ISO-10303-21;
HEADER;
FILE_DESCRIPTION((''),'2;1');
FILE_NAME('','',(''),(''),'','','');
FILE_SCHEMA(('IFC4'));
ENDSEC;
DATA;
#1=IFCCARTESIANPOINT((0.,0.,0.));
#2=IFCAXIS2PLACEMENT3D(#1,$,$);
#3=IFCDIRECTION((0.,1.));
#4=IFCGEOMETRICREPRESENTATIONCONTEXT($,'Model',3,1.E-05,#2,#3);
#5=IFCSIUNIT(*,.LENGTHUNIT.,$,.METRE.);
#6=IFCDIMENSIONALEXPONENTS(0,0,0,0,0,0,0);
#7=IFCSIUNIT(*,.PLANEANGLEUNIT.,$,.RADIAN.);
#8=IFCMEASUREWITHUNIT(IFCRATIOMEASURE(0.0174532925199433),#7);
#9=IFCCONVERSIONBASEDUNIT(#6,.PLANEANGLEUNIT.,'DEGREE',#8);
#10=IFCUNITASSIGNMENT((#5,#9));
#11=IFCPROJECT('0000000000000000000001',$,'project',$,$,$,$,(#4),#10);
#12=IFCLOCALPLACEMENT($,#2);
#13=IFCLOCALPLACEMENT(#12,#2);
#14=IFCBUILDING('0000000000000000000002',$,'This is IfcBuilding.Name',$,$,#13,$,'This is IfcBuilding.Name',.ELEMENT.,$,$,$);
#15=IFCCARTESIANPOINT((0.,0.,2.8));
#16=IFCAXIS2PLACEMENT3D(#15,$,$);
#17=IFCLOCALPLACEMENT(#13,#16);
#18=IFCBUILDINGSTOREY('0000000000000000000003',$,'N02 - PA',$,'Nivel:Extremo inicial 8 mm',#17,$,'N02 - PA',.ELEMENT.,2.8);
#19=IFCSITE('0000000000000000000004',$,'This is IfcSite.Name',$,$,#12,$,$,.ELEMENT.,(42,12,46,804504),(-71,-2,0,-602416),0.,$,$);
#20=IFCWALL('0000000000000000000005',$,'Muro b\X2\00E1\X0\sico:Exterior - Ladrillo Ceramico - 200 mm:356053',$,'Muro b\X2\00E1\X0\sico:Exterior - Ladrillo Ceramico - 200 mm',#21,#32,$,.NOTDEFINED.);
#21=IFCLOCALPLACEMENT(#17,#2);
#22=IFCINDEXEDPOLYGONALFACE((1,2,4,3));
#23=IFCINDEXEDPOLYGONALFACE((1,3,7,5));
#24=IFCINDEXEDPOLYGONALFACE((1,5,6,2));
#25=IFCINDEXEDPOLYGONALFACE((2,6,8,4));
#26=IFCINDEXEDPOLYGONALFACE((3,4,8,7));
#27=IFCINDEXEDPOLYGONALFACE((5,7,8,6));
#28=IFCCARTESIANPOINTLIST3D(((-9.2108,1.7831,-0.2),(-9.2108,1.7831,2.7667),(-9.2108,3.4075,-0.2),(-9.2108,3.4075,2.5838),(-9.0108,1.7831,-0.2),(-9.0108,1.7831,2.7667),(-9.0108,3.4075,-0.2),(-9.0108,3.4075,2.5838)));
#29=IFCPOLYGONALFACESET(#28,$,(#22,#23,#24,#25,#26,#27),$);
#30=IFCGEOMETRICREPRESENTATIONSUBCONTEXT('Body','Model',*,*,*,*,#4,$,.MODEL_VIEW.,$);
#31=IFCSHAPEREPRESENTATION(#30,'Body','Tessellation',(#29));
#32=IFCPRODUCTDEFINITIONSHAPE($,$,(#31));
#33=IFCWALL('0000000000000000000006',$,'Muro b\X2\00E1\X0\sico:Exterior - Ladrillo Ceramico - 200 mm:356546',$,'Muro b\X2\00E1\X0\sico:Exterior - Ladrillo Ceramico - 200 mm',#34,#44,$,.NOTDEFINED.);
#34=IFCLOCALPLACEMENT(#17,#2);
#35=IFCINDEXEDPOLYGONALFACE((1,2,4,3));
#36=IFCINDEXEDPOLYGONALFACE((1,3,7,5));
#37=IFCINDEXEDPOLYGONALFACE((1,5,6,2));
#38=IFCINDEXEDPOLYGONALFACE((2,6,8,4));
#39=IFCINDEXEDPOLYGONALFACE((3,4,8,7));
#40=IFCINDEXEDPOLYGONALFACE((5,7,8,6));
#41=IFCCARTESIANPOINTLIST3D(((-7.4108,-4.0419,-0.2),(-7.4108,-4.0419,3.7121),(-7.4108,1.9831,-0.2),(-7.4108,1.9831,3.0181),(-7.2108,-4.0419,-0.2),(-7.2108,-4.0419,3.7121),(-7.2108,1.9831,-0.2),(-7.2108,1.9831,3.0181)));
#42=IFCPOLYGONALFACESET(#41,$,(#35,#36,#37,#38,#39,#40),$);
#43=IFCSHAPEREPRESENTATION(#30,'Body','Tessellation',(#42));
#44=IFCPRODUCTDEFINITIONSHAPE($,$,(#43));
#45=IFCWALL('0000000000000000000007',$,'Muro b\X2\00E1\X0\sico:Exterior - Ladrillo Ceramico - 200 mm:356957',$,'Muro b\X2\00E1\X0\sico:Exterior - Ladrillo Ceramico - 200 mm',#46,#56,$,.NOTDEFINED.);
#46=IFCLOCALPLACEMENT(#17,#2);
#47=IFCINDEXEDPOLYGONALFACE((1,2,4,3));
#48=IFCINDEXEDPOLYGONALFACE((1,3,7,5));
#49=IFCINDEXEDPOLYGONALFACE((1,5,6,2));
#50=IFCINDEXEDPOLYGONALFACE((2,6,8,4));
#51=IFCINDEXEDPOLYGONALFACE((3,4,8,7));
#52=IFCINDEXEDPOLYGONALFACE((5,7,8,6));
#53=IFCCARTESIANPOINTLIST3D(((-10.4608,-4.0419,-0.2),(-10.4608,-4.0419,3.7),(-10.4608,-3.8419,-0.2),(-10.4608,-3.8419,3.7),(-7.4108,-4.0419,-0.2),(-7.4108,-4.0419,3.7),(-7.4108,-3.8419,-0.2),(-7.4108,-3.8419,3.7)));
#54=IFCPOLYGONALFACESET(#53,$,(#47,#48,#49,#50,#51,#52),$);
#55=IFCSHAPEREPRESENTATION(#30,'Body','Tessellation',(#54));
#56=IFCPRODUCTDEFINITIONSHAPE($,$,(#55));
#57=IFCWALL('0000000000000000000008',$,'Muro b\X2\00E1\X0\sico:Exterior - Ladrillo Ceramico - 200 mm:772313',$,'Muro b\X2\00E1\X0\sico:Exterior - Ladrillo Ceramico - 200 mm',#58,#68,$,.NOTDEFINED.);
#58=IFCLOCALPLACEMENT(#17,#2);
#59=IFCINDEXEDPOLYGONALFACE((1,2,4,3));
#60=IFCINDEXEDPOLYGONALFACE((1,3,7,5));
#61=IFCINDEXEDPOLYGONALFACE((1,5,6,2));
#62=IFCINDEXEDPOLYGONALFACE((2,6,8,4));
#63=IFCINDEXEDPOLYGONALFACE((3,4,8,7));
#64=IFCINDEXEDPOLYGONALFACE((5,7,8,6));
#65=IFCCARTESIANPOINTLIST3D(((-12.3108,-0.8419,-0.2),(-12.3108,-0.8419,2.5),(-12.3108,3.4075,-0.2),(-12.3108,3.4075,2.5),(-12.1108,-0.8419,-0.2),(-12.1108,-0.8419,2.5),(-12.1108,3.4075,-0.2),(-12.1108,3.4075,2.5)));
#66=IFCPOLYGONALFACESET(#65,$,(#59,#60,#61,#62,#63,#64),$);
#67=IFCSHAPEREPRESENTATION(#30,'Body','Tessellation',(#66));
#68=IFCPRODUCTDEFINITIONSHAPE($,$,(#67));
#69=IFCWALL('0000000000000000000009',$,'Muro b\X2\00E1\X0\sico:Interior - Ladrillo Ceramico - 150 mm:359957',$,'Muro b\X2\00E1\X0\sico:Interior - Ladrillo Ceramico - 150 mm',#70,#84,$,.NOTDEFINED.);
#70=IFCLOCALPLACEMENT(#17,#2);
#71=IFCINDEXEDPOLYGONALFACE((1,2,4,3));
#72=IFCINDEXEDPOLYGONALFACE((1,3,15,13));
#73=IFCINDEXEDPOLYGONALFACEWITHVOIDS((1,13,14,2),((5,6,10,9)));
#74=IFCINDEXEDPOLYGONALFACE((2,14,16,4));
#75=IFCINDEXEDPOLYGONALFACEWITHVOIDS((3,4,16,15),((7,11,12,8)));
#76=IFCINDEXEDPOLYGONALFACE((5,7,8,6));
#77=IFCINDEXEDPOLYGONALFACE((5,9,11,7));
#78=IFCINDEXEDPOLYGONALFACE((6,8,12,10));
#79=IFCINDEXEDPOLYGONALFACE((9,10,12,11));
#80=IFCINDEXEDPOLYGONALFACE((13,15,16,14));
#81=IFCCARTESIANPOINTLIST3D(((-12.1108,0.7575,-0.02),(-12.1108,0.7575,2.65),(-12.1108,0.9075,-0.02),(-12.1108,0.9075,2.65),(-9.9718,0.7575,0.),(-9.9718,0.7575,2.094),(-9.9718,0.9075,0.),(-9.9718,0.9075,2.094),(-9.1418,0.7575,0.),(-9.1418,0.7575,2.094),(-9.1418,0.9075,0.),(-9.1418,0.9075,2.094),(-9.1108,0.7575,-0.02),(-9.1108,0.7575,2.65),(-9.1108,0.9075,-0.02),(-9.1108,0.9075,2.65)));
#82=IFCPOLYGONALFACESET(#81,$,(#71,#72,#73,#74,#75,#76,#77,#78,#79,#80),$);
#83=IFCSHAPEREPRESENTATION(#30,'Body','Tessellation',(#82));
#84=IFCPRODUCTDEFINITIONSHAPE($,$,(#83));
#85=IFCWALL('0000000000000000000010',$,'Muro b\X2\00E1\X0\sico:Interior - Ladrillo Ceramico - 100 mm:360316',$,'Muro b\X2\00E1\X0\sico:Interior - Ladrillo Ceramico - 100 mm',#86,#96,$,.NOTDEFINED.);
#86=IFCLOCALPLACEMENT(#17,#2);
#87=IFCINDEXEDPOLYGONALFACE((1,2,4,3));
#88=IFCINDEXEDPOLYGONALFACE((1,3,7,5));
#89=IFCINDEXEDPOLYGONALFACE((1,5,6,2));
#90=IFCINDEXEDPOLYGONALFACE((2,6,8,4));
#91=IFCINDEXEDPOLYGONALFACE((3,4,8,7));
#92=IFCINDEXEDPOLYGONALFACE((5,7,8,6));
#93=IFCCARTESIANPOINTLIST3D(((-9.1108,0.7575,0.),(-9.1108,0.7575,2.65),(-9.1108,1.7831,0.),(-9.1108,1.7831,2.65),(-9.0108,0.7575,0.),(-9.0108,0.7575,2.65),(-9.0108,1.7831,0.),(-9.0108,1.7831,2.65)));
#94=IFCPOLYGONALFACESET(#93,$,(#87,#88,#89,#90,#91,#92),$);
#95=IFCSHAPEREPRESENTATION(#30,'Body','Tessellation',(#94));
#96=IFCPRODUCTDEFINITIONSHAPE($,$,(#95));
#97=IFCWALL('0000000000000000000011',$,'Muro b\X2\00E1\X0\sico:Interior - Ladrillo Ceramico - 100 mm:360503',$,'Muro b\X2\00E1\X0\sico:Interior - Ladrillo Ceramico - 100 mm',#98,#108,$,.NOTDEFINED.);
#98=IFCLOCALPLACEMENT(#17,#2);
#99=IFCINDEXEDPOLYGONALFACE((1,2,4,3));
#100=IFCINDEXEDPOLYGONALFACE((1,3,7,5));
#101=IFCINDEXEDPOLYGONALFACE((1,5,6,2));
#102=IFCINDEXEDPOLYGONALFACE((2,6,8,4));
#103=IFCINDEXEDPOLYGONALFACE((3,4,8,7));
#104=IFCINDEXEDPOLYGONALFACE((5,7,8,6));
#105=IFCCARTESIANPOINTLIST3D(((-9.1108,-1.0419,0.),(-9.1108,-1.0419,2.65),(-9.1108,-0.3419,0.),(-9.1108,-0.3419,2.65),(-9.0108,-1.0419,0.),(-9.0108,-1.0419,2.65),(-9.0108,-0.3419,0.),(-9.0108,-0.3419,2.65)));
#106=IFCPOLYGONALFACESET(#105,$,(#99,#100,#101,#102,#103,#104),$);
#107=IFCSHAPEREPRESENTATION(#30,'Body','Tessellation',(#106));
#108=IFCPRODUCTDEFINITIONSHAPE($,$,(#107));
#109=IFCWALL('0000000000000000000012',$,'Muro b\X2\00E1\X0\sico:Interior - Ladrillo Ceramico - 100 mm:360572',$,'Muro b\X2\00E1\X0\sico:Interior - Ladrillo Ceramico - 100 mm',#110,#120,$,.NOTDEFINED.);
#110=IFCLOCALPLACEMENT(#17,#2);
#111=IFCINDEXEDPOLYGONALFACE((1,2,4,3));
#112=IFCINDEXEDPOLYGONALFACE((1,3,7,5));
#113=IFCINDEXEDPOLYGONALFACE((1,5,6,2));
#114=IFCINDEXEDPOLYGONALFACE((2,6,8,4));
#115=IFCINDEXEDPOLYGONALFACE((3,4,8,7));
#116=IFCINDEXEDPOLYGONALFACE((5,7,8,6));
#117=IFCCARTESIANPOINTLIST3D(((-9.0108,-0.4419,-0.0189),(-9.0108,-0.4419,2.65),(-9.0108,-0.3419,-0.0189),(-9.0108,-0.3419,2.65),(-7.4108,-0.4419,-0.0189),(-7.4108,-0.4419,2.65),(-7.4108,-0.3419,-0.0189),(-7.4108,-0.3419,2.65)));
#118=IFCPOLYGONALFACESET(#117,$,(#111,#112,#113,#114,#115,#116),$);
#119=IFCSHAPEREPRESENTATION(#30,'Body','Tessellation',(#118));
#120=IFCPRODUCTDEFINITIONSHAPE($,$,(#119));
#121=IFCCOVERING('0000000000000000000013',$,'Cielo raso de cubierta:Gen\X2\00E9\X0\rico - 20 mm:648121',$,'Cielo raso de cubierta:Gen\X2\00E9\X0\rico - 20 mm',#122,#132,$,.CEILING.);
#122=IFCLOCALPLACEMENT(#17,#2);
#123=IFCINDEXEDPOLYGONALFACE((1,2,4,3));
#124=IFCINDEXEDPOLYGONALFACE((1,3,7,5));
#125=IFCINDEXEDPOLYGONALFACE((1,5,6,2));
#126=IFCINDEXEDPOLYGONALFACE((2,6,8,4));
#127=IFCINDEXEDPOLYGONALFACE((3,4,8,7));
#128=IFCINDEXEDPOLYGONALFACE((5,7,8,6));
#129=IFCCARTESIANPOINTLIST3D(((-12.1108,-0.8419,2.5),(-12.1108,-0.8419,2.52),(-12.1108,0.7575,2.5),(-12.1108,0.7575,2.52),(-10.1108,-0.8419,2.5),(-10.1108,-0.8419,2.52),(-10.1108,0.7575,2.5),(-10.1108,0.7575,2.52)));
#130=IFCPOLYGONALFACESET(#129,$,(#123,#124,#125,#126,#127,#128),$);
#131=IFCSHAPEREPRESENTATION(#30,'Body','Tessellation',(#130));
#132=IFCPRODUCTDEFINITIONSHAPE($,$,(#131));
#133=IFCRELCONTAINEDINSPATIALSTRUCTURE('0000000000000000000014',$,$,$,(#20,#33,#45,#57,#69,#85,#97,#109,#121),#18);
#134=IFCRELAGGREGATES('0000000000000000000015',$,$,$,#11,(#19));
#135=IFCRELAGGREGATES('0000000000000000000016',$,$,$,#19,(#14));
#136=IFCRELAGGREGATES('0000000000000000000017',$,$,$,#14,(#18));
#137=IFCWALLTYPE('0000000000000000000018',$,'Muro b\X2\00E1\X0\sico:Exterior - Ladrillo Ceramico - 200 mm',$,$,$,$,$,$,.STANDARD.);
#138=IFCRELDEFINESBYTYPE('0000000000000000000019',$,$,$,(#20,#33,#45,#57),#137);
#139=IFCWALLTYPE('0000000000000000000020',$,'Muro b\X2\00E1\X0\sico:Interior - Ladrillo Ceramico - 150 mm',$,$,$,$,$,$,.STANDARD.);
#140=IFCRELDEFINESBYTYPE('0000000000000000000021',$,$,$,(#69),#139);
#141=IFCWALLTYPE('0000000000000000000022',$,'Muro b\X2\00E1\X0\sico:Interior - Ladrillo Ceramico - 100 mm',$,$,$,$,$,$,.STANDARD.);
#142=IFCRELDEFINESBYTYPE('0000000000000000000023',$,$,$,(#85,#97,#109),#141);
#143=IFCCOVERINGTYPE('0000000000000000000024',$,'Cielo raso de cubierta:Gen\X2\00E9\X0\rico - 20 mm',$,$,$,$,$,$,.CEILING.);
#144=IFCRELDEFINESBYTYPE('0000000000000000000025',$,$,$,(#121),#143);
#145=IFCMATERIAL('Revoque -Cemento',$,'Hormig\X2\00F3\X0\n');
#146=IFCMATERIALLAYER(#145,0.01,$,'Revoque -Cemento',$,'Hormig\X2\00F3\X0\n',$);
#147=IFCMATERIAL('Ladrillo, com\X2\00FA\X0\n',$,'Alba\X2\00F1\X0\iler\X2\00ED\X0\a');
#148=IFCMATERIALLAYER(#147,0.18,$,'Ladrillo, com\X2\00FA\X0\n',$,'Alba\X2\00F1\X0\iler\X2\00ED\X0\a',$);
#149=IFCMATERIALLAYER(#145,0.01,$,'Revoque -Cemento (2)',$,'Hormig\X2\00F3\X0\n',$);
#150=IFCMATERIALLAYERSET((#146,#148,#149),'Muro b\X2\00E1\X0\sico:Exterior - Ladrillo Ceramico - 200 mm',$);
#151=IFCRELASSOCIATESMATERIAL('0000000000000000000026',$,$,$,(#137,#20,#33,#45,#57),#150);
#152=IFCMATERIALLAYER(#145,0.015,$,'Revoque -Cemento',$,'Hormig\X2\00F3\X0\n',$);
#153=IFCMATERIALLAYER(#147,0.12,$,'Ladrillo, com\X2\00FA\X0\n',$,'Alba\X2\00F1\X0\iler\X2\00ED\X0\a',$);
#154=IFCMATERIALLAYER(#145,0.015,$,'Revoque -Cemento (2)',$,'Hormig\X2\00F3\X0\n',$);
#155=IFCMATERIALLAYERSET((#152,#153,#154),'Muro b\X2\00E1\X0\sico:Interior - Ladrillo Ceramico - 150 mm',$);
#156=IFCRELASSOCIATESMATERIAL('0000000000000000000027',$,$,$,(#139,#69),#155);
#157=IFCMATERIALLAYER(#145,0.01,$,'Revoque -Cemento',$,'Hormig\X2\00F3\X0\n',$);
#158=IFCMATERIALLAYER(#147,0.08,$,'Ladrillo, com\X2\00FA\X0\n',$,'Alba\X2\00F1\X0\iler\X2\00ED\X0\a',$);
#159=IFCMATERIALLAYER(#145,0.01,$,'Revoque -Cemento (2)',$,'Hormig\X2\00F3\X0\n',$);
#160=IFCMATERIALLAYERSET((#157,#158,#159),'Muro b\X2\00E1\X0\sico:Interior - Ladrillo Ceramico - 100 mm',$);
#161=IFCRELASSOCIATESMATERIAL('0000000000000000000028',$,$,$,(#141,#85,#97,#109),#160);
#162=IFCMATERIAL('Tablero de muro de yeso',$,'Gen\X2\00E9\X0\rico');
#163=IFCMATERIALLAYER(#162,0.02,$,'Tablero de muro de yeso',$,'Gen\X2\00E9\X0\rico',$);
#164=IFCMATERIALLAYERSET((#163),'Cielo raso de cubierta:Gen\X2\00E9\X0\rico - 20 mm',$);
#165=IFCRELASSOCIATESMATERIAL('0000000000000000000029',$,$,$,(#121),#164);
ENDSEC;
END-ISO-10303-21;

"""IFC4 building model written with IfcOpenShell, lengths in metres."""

from ifc_helpers import new_model, entity, si_unit, converted_unit, direction, frame, frame_2d, origin, place, context, subcontext, project, spatial, polyline, rectangle, extrude, clip, halfspace, bounded_halfspace, material, layer, layer_set, layer_usage, type_object, element, save


model = new_model("IFC4")

# Units and contexts
model_context = context("Model", 3, precision=1e-05, world=origin(), true_north=direction((0.0, 1.0)))
body_context = subcontext(model_context, "Body", "Model", "MODEL_VIEW")
ifc_project = project(units=[si_unit("LENGTHUNIT", "METRE"), converted_unit("PLANEANGLEUNIT", "DEGREE", entity("IfcRatioMeasure", 0.0174532925199433), si_unit("PLANEANGLEUNIT", "RADIAN"), dimensions=[0, 0, 0, 0, 0, 0, 0])], contexts=[model_context])

# Site, building, storey
site_placement = place(None, origin())
site = spatial("IfcSite", under=ifc_project, at=site_placement, Name="This is IfcSite.Name", CompositionType="ELEMENT", RefLatitude=(42, 12, 46, 804504), RefLongitude=(-71, -2, 0, -602416), RefElevation=0.0)
building_placement = place(site_placement, origin())
building = spatial("IfcBuilding", under=site, at=building_placement, Name="This is IfcBuilding.Name", LongName="This is IfcBuilding.Name", CompositionType="ELEMENT")
storey_placement = place(building_placement, frame((0.0, 0.0, 2.8)))
storey = spatial("IfcBuildingStorey", under=building, at=storey_placement, Name="N02 - PA", ObjectType="Nivel:Extremo inicial 8 mm", LongName="N02 - PA", CompositionType="ELEMENT", Elevation=2.8)

# Shared definitions
ifc_material_1 = material(Name="Revoque -Cemento", Category="Hormigón")

# Walls
ifc_layer_1 = layer(ifc_material_1, 0.01, Name="Revoque -Cemento", Category="Hormigón")
ifc_material_2 = material(Name="Ladrillo, común", Category="Albañilería")
ifc_layer_2 = layer(ifc_material_2, 0.18, Name="Ladrillo, común", Category="Albañilería")
ifc_layer_3 = layer(ifc_material_1, 0.01, Name="Revoque -Cemento (2)", Category="Hormigón")
ifc_layer_set_1 = layer_set([ifc_layer_1, ifc_layer_2, ifc_layer_3], Name="Muro básico:Exterior - Ladrillo Ceramico - 200 mm")
ifc_layer_usage_1 = layer_usage(ifc_layer_set_1, "AXIS2", "NEGATIVE", 0.1)
wall_type_1 = type_object("IfcWallType", Name="Muro básico:Exterior - Ladrillo Ceramico - 200 mm", PredefinedType="STANDARD", material=ifc_layer_set_1)
wall_1_placement = place(storey_placement, frame((-9.1108, 3.4075, -0.2), z_axis=(0.0, 0.0, 1.0), x_axis=(0.0, -1.0, 0.0)))
element("IfcWall", 1, at=wall_1_placement, inside=storey, type_object=wall_type_1, material=ifc_layer_usage_1, Name="Muro básico:Exterior - Ladrillo Ceramico - 200 mm:356053", ObjectType="Muro básico:Exterior - Ladrillo Ceramico - 200 mm", PredefinedType="NOTDEFINED", context=body_context, shape_type="Clipping", body=[
    clip(extrude(rectangle(XDim=1.6244, YDim=0.2, at=frame_2d((0.8122, 0.0), x_axis=(-1.0, 0.0))), origin(), (0.0, 0.0, 1.0), 2.9667), bounded_halfspace(frame((0.0, -0.1, 2.7838), z_axis=(-0.111886, 0.0, 0.993721), x_axis=(0.0, -1.0, 0.0)), False, frame((0.0, -0.1, 2.7838)), polyline([(0.0, 0.0), (1.6244, 0.0), (1.6244, 0.2), (1.4244, 0.2), (1.3244, 0.2), (0.0, 0.2), (0.0, 0.0)]))),
])
ifc_layer_usage_2 = layer_usage(ifc_layer_set_1, "AXIS2", "NEGATIVE", 0.1)
wall_2_placement = place(storey_placement, frame((-7.3108, 1.9831, -0.2), z_axis=(0.0, 0.0, 1.0), x_axis=(0.0, -1.0, 0.0)))
element("IfcWall", 2, at=wall_2_placement, inside=storey, type_object=wall_type_1, material=ifc_layer_usage_2, Name="Muro básico:Exterior - Ladrillo Ceramico - 200 mm:356546", ObjectType="Muro básico:Exterior - Ladrillo Ceramico - 200 mm", PredefinedType="NOTDEFINED", context=body_context, shape_type="Clipping", body=[
    clip(extrude(rectangle(XDim=6.025, YDim=0.2, at=frame_2d((3.0125, 0.0), x_axis=(-1.0, 0.0))), origin(), (0.0, 0.0, 1.0), 3.9121), halfspace(frame((0.0, -0.1, 3.2181), z_axis=(-0.114424, 0.0, 0.993432), x_axis=(0.0, 1.0, 0.0)), False)),
])
ifc_layer_usage_3 = layer_usage(ifc_layer_set_1, "AXIS2", "NEGATIVE", 0.1)
wall_3_placement = place(storey_placement, frame((-7.4108, -3.9419, -0.2), z_axis=(0.0, 0.0, 1.0), x_axis=(-1.0, 0.0, 0.0)))
element("IfcWall", 3, at=wall_3_placement, inside=storey, type_object=wall_type_1, material=ifc_layer_usage_3, Name="Muro básico:Exterior - Ladrillo Ceramico - 200 mm:356957", ObjectType="Muro básico:Exterior - Ladrillo Ceramico - 200 mm", PredefinedType="NOTDEFINED", context=body_context, shape_type="SweptSolid", body=[
    extrude(rectangle(XDim=3.05, YDim=0.2, at=frame_2d((1.525, 0.0), x_axis=(-1.0, 0.0))), origin(), (0.0, 0.0, 1.0), 3.9),
])
ifc_layer_usage_4 = layer_usage(ifc_layer_set_1, "AXIS2", "POSITIVE", -0.1)
wall_4_placement = place(storey_placement, frame((-12.2108, 3.4075, -0.2), z_axis=(0.0, 0.0, 1.0), x_axis=(0.0, -1.0, 0.0)))
element("IfcWall", 4, at=wall_4_placement, inside=storey, type_object=wall_type_1, material=ifc_layer_usage_4, Name="Muro básico:Exterior - Ladrillo Ceramico - 200 mm:772313", ObjectType="Muro básico:Exterior - Ladrillo Ceramico - 200 mm", PredefinedType="NOTDEFINED", context=body_context, shape_type="SweptSolid", body=[
    extrude(rectangle(XDim=4.2494, YDim=0.2, at=frame_2d((2.1247, 0.0), x_axis=(-1.0, 0.0))), origin(), (0.0, 0.0, 1.0), 2.7),
])

# Wall, opening
ifc_layer_4 = layer(ifc_material_1, 0.015, Name="Revoque -Cemento", Category="Hormigón")
ifc_layer_5 = layer(ifc_material_2, 0.12, Name="Ladrillo, común", Category="Albañilería")
ifc_layer_6 = layer(ifc_material_1, 0.015, Name="Revoque -Cemento (2)", Category="Hormigón")
ifc_layer_set_2 = layer_set([ifc_layer_4, ifc_layer_5, ifc_layer_6], Name="Muro básico:Interior - Ladrillo Ceramico - 150 mm")
ifc_layer_usage_5 = layer_usage(ifc_layer_set_2, "AXIS2", "NEGATIVE", 0.075)
wall_type_2 = type_object("IfcWallType", Name="Muro básico:Interior - Ladrillo Ceramico - 150 mm", PredefinedType="STANDARD", material=ifc_layer_set_2)
wall_5_placement = place(storey_placement, frame((-9.1108, 0.8325, -0.02), z_axis=(0.0, 0.0, 1.0), x_axis=(-1.0, 0.0, 0.0)))
wall_5 = element("IfcWall", 5, at=wall_5_placement, inside=storey, type_object=wall_type_2, material=ifc_layer_usage_5, Name="Muro básico:Interior - Ladrillo Ceramico - 150 mm:359957", ObjectType="Muro básico:Interior - Ladrillo Ceramico - 150 mm", PredefinedType="NOTDEFINED", context=body_context, shape_type="SweptSolid", body=[
    extrude(rectangle(XDim=3.0, YDim=0.15, at=frame_2d((1.5, 0.0), x_axis=(-1.0, 0.0))), origin(), (0.0, 0.0, 1.0), 2.67),
])
opening_1_placement = place(wall_5_placement, frame((0.861, 0.075, 0.02)))
element("IfcOpeningElement", 6, at=opening_1_placement, cuts=wall_5, PredefinedType="OPENING", context=body_context, shape_type="SweptSolid", body=[
    extrude(rectangle(XDim=2.094, YDim=0.83, at=frame_2d((1.047, 0.415), x_axis=(-1.0, 0.0))), frame((0.0, 0.0, 0.0), z_axis=(0.0, -1.0, 0.0), x_axis=(0.0, 0.0, 1.0)), (0.0, 0.0, 1.0), 0.15),
])

# Walls
ifc_layer_7 = layer(ifc_material_1, 0.01, Name="Revoque -Cemento", Category="Hormigón")
ifc_layer_8 = layer(ifc_material_2, 0.08, Name="Ladrillo, común", Category="Albañilería")
ifc_layer_9 = layer(ifc_material_1, 0.01, Name="Revoque -Cemento (2)", Category="Hormigón")
ifc_layer_set_3 = layer_set([ifc_layer_7, ifc_layer_8, ifc_layer_9], Name="Muro básico:Interior - Ladrillo Ceramico - 100 mm")
ifc_layer_usage_6 = layer_usage(ifc_layer_set_3, "AXIS2", "NEGATIVE", 0.05)
wall_type_3 = type_object("IfcWallType", Name="Muro básico:Interior - Ladrillo Ceramico - 100 mm", PredefinedType="STANDARD", material=ifc_layer_set_3)
wall_6_placement = place(storey_placement, frame((-9.0608, 1.7831, 0.0), z_axis=(0.0, 0.0, 1.0), x_axis=(0.0, -1.0, 0.0)))
element("IfcWall", 7, at=wall_6_placement, inside=storey, type_object=wall_type_3, material=ifc_layer_usage_6, Name="Muro básico:Interior - Ladrillo Ceramico - 100 mm:360316", ObjectType="Muro básico:Interior - Ladrillo Ceramico - 100 mm", PredefinedType="NOTDEFINED", context=body_context, shape_type="SweptSolid", body=[
    extrude(rectangle(XDim=1.0256, YDim=0.1, at=frame_2d((0.5128, 0.0), x_axis=(-1.0, 0.0))), origin(), (0.0, 0.0, 1.0), 2.65),
])
ifc_layer_usage_7 = layer_usage(ifc_layer_set_3, "AXIS2", "POSITIVE", -0.05)
wall_7_placement = place(storey_placement, frame((-9.0608, -1.0419, 0.0), z_axis=(0.0, 0.0, 1.0), x_axis=(0.0, 1.0, 0.0)))
element("IfcWall", 8, at=wall_7_placement, inside=storey, type_object=wall_type_3, material=ifc_layer_usage_7, Name="Muro básico:Interior - Ladrillo Ceramico - 100 mm:360503", ObjectType="Muro básico:Interior - Ladrillo Ceramico - 100 mm", PredefinedType="NOTDEFINED", context=body_context, shape_type="SweptSolid", body=[
    extrude(rectangle(XDim=0.7, YDim=0.1, at=frame_2d((0.35, 0.0), x_axis=(-1.0, 0.0))), origin(), (0.0, 0.0, 1.0), 2.65),
])
ifc_layer_usage_8 = layer_usage(ifc_layer_set_3, "AXIS2", "POSITIVE", -0.05)
wall_8_placement = place(storey_placement, frame((-9.0108, -0.3919, -0.0189)))
element("IfcWall", 9, at=wall_8_placement, inside=storey, type_object=wall_type_3, material=ifc_layer_usage_8, Name="Muro básico:Interior - Ladrillo Ceramico - 100 mm:360572", ObjectType="Muro básico:Interior - Ladrillo Ceramico - 100 mm", PredefinedType="NOTDEFINED", context=body_context, shape_type="SweptSolid", body=[
    extrude(rectangle(XDim=1.6, YDim=0.1, at=frame_2d((0.8, 0.0), x_axis=(-1.0, 0.0))), origin(), (0.0, 0.0, 1.0), 2.6689),
])

# Covering
ifc_material_3 = material(Name="Tablero de muro de yeso", Category="Genérico")
ifc_layer_10 = layer(ifc_material_3, 0.02, Name="Tablero de muro de yeso", Category="Genérico")
ifc_layer_set_4 = layer_set([ifc_layer_10], Name="Cielo raso de cubierta:Genérico - 20 mm")
ifc_layer_usage_9 = layer_usage(ifc_layer_set_4, "AXIS3", "POSITIVE", 0.0)
covering_type_1 = type_object("IfcCoveringType", Name="Cielo raso de cubierta:Genérico - 20 mm", PredefinedType="CEILING")
covering_1_placement = place(storey_placement, frame((-12.1108, -0.8419, 2.5)))
element("IfcCovering", 10, at=covering_1_placement, inside=storey, type_object=covering_type_1, material=ifc_layer_usage_9, Name="Cielo raso de cubierta:Genérico - 20 mm:648121", ObjectType="Cielo raso de cubierta:Genérico - 20 mm", PredefinedType="CEILING", context=body_context, shape_type="SweptSolid", body=[
    extrude(rectangle(XDim=2.0, YDim=1.5994, at=frame_2d((0.0, 0.0), x_axis=(1.0, 0.0))), frame((1.0, 0.7997, 0.0)), (0.0, 0.0, 1.0), 0.02),
])

save(model, "model.ifc")
